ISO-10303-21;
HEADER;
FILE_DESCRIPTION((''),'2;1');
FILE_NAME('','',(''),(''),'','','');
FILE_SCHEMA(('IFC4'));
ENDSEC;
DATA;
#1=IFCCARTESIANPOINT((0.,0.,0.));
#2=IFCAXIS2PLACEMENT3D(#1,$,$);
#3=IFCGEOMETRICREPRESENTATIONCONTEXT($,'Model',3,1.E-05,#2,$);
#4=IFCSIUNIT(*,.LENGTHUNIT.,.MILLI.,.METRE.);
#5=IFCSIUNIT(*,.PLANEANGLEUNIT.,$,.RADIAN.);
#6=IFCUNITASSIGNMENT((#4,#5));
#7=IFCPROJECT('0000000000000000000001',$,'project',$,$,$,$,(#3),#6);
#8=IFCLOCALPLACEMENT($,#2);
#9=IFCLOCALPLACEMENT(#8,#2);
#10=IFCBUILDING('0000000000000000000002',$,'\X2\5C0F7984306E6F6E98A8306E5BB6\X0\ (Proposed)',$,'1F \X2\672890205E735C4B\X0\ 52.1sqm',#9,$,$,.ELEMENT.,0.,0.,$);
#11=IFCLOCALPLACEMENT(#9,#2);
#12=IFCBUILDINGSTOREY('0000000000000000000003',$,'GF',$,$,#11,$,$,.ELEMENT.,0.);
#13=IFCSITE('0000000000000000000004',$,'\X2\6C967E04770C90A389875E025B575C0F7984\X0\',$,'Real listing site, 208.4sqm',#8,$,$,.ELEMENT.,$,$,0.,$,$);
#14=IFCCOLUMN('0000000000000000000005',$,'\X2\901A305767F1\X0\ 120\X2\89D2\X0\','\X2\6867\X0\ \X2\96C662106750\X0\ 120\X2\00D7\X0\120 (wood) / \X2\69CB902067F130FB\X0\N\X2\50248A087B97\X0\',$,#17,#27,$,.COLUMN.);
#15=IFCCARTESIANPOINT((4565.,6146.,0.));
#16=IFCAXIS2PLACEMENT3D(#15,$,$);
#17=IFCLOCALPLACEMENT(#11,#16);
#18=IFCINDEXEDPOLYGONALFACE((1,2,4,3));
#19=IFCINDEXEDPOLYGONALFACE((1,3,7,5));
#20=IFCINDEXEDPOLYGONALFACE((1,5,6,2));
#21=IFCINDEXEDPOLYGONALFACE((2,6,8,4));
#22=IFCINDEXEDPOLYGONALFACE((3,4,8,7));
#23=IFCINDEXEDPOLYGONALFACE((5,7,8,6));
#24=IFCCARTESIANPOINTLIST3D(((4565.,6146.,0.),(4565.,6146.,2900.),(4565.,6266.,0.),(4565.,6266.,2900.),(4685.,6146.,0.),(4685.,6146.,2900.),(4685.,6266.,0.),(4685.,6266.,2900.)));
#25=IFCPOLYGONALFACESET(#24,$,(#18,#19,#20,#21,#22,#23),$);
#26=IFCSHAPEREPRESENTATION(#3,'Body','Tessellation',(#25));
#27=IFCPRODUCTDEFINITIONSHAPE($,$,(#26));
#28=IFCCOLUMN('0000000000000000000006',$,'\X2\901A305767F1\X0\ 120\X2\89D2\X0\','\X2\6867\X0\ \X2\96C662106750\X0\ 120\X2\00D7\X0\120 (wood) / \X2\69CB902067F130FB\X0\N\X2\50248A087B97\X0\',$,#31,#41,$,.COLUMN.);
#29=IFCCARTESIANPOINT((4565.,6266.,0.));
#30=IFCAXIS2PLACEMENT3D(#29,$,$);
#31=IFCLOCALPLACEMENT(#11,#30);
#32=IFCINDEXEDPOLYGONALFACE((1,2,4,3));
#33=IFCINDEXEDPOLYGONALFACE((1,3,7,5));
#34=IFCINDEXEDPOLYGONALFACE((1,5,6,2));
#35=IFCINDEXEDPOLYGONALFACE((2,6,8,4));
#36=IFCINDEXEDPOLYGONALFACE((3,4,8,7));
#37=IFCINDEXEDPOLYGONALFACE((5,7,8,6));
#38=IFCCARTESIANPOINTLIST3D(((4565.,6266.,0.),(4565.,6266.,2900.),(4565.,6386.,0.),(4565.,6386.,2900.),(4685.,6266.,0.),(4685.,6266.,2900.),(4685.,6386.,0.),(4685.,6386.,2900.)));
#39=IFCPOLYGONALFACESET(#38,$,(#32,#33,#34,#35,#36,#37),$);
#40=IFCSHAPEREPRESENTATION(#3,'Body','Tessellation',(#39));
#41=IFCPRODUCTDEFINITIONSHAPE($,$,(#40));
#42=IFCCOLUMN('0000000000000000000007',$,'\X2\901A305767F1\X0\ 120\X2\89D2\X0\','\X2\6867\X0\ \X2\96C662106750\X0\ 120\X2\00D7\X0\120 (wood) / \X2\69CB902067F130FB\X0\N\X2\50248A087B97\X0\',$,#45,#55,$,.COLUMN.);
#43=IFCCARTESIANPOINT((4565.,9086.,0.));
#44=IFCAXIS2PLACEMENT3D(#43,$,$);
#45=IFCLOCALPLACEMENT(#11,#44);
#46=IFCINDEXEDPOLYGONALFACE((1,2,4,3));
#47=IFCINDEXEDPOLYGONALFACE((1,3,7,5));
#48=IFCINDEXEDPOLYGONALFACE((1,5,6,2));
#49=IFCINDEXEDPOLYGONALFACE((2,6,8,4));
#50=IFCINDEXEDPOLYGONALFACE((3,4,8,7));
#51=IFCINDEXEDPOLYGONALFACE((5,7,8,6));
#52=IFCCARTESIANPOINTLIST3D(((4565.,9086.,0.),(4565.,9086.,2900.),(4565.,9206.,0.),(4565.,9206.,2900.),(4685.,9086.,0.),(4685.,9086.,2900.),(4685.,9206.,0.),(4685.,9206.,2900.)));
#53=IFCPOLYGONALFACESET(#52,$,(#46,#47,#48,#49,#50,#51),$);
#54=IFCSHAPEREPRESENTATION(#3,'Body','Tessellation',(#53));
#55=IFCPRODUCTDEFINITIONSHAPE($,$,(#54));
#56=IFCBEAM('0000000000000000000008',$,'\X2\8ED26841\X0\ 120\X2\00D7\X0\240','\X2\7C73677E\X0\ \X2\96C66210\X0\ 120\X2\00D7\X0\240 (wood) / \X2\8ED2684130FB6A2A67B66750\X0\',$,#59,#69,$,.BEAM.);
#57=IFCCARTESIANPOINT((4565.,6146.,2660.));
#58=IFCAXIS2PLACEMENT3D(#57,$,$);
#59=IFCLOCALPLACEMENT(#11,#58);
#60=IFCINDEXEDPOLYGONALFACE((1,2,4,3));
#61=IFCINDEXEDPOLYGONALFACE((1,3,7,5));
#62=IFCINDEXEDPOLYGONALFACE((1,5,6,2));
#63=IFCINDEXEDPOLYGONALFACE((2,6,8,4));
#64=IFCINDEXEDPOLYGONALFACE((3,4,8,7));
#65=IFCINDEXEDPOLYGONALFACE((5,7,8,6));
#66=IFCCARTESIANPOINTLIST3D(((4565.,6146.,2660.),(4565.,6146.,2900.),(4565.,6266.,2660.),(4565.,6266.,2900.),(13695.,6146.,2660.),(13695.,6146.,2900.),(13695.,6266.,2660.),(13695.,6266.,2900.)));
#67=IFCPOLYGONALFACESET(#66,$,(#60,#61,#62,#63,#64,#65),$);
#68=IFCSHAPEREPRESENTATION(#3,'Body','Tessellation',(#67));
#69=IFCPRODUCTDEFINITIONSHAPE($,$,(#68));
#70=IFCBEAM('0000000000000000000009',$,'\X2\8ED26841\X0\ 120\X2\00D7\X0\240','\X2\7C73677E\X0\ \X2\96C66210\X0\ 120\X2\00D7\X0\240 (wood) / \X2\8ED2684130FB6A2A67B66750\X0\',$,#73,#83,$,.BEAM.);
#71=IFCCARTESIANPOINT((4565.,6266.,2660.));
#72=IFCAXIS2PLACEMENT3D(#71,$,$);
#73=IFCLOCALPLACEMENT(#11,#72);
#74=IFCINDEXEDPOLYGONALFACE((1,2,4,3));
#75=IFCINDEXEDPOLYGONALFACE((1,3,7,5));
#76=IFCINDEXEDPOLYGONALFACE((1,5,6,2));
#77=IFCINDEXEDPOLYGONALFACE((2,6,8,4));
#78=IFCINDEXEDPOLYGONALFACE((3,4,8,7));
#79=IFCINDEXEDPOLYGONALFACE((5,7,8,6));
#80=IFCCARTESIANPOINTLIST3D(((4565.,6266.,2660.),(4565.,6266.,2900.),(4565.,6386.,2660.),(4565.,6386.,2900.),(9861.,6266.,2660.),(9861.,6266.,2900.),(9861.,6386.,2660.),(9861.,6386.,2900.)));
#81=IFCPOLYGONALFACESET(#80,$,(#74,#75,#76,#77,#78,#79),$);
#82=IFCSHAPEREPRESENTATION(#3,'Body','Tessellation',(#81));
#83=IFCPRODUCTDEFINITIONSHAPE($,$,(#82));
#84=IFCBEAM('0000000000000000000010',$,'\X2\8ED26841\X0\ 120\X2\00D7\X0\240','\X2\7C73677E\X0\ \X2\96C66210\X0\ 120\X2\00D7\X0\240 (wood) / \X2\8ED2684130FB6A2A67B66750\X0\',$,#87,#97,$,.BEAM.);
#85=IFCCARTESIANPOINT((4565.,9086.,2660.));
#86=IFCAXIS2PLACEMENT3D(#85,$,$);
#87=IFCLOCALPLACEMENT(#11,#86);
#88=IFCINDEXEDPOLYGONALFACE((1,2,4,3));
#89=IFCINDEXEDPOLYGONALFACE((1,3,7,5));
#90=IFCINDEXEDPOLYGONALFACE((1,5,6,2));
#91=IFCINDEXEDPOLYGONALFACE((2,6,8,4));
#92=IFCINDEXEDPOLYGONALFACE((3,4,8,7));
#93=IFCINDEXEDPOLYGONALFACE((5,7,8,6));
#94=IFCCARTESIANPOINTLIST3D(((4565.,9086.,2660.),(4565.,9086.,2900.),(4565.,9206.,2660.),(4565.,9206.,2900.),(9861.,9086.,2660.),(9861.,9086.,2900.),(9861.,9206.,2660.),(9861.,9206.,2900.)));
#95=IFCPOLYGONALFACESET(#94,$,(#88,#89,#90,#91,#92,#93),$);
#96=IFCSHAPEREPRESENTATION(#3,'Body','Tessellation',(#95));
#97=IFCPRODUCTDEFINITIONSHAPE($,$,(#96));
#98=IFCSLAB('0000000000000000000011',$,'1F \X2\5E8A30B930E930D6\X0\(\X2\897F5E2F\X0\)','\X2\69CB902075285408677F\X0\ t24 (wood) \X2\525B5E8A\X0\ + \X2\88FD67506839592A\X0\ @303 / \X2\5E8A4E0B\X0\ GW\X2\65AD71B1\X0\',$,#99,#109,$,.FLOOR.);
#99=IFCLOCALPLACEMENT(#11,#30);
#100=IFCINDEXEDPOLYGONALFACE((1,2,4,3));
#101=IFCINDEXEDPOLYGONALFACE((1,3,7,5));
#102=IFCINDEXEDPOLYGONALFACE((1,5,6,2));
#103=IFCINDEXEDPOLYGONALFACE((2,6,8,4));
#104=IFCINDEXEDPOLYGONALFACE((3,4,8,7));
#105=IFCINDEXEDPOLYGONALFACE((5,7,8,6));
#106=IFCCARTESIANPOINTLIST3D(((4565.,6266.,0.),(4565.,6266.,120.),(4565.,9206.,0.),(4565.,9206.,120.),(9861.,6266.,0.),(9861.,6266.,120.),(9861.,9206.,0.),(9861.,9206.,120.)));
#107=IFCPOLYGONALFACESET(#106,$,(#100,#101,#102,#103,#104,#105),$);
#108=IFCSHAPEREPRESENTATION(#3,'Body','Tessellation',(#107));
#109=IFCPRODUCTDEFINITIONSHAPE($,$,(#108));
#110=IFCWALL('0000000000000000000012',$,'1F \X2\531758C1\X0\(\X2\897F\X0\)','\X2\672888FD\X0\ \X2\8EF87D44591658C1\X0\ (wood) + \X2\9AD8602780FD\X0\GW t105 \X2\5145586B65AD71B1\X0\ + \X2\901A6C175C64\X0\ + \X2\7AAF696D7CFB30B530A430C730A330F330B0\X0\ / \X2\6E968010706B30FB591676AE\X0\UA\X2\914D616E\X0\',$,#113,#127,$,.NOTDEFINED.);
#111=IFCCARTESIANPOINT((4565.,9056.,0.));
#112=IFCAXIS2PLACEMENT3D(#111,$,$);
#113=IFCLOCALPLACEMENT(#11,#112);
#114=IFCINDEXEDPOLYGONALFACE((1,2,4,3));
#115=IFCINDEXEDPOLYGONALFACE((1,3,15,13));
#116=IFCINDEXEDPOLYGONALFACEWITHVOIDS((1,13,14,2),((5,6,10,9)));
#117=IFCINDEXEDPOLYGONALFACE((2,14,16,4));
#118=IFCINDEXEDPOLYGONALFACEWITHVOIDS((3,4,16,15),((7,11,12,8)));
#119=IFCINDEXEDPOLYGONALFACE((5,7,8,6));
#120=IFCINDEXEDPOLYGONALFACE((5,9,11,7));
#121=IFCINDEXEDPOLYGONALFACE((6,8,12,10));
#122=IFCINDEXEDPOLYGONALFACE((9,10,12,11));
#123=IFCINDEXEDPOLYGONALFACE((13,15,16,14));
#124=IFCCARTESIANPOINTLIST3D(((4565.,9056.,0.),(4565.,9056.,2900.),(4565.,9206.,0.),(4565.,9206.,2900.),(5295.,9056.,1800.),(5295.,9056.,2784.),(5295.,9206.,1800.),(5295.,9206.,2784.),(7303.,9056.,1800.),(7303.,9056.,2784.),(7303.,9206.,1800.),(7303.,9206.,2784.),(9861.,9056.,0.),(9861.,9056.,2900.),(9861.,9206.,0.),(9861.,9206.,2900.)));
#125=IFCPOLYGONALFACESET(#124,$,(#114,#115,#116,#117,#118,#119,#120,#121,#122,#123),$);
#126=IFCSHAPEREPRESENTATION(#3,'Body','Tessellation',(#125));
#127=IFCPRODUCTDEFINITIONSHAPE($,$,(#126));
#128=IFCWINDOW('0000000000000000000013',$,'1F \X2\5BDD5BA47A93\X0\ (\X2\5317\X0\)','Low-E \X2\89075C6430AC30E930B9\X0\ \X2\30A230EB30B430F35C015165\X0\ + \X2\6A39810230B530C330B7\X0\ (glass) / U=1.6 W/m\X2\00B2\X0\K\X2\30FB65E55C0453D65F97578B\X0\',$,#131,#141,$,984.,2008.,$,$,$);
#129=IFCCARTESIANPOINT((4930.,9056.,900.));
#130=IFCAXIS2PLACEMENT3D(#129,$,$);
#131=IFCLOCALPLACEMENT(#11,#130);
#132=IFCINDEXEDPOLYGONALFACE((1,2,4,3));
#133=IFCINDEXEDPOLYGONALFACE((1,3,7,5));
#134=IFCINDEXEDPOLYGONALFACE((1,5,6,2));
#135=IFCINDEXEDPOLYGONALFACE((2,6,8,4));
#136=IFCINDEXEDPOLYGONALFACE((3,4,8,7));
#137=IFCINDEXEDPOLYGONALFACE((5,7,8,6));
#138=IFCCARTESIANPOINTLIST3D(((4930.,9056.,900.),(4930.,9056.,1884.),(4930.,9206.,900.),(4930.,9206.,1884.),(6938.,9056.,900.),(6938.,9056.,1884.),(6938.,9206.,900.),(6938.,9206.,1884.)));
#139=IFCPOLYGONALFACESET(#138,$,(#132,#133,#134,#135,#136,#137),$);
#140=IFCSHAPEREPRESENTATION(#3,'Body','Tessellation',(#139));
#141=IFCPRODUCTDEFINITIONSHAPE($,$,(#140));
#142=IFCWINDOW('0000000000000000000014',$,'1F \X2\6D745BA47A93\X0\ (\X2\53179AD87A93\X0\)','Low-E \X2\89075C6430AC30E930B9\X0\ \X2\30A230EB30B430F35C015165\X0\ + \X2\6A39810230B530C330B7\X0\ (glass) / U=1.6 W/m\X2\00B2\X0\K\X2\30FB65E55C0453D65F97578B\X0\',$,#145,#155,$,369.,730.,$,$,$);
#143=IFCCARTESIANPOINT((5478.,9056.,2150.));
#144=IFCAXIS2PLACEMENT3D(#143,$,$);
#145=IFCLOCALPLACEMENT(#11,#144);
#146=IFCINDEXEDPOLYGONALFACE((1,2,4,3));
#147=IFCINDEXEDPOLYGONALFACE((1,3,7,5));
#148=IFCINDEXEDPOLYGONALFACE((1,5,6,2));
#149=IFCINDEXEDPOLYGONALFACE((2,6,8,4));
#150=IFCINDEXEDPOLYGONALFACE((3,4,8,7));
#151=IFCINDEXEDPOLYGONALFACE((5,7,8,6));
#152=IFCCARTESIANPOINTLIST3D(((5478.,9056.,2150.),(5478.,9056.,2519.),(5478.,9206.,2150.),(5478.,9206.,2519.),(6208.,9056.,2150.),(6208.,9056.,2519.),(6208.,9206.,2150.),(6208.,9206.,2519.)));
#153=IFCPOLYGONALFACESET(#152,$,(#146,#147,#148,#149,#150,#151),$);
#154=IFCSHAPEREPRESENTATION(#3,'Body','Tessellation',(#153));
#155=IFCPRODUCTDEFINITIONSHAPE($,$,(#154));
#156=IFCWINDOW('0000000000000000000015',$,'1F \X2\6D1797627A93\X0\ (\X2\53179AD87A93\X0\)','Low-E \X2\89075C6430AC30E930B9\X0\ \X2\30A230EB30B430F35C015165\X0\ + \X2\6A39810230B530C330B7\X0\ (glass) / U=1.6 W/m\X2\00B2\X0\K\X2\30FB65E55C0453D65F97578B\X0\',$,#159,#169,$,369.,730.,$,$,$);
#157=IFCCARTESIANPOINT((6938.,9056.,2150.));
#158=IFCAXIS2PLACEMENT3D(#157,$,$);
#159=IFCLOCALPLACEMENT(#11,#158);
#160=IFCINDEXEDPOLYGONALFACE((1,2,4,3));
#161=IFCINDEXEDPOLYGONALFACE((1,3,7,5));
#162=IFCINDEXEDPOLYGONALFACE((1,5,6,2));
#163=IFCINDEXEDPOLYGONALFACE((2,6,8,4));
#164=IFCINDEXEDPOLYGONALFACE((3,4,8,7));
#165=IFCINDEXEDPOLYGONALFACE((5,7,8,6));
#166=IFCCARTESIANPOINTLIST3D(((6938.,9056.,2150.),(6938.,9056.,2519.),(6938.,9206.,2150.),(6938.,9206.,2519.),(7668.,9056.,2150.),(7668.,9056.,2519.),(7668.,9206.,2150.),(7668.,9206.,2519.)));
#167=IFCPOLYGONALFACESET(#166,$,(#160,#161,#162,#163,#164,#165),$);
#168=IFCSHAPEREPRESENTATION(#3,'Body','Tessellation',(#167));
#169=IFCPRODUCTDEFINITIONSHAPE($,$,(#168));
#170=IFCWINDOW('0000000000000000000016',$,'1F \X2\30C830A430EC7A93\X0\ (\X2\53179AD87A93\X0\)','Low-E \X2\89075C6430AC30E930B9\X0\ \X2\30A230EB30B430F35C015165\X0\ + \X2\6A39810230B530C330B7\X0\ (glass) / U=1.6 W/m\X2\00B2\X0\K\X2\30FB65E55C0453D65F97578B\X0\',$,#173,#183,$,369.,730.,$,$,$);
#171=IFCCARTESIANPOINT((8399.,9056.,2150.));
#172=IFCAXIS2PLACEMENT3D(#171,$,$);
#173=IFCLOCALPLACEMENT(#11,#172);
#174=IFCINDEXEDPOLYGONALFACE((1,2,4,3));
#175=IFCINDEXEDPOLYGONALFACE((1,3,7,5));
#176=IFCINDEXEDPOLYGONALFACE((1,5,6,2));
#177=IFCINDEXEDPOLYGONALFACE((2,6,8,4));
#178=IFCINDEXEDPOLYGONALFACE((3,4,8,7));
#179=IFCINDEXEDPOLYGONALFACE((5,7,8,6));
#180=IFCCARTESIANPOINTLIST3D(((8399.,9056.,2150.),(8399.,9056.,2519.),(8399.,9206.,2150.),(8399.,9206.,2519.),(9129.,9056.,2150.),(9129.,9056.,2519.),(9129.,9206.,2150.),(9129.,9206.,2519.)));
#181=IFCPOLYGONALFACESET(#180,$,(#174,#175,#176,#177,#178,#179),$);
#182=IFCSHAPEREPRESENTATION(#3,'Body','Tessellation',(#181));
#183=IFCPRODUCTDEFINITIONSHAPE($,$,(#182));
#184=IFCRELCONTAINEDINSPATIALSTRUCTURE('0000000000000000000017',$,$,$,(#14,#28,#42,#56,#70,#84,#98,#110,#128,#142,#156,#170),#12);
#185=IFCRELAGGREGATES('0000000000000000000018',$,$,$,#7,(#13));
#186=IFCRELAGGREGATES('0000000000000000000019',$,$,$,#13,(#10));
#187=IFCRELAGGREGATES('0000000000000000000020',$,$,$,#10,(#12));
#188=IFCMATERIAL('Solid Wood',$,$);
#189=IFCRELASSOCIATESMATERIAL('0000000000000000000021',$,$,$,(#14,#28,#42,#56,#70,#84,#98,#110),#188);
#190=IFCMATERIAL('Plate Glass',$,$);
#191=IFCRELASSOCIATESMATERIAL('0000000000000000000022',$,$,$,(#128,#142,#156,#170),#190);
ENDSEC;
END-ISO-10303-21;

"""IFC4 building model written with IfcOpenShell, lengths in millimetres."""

from ifc_helpers import new_model, si_unit, frame, frame_2d, origin, place, context, project, spatial, rectangle, extrude, material, element, fill, save


model = new_model("IFC4")

# Units and contexts
model_context = context("Model", 3, precision=1e-05, world=origin())
ifc_project = project(units=[si_unit("LENGTHUNIT", "METRE", prefix="MILLI"), si_unit("PLANEANGLEUNIT", "RADIAN")], contexts=[model_context])

# Site, building, storey
site_placement = place(None, origin())
site = spatial("IfcSite", under=ifc_project, at=site_placement, Name="沖縄県那覇市字小禄", ObjectType="Real listing site, 208.4sqm", CompositionType="ELEMENT", RefElevation=0.0)
building_placement = place(site_placement, origin())
building = spatial("IfcBuilding", under=site, at=building_placement, Name="小禄の潮風の家 (Proposed)", ObjectType="1F 木造平屋 52.1sqm", CompositionType="ELEMENT", ElevationOfRefHeight=0.0, ElevationOfTerrain=0.0)
storey_placement = place(building_placement, origin())
storey = spatial("IfcBuildingStorey", under=building, at=storey_placement, Name="GF", CompositionType="ELEMENT", Elevation=0.0)

# Columns
ifc_material_1 = material(Name="Solid Wood")
column_1_placement = place(storey_placement, frame((4565.0, 6146.0, 0.0)))
element("IfcColumn", 1, at=column_1_placement, inside=storey, material=ifc_material_1, Name="通し柱 120角", Description="桧 集成材 120×120 (wood) / 構造柱・N値計算", PredefinedType="COLUMN", context=model_context, shape_type="SweptSolid", body=[
    extrude(rectangle(XDim=120.0, YDim=120.0, at=frame_2d((60.0, 60.0))), frame((4565.0, 6146.0, 0.0)), (0.0, 0.0, 1.0), 2900.0),
])
column_2_placement = place(storey_placement, frame((4565.0, 6266.0, 0.0)))
element("IfcColumn", 2, at=column_2_placement, inside=storey, material=ifc_material_1, Name="通し柱 120角", Description="桧 集成材 120×120 (wood) / 構造柱・N値計算", PredefinedType="COLUMN", context=model_context, shape_type="SweptSolid", body=[
    extrude(rectangle(XDim=120.0, YDim=120.0, at=frame_2d((60.0, 60.0))), frame((4565.0, 6266.0, 0.0)), (0.0, 0.0, 1.0), 2900.0),
])
column_3_placement = place(storey_placement, frame((4565.0, 9086.0, 0.0)))
element("IfcColumn", 3, at=column_3_placement, inside=storey, material=ifc_material_1, Name="通し柱 120角", Description="桧 集成材 120×120 (wood) / 構造柱・N値計算", PredefinedType="COLUMN", context=model_context, shape_type="SweptSolid", body=[
    extrude(rectangle(XDim=120.0, YDim=120.0, at=frame_2d((60.0, 60.0))), frame((4565.0, 9086.0, 0.0)), (0.0, 0.0, 1.0), 2900.0),
])

# Beams
beam_1_placement = place(storey_placement, frame((4565.0, 6146.0, 2660.0)))
element("IfcBeam", 4, at=beam_1_placement, inside=storey, material=ifc_material_1, Name="軒桁 120×240", Description="米松 集成 120×240 (wood) / 軒桁・横架材", PredefinedType="BEAM", context=model_context, shape_type="SweptSolid", body=[
    extrude(rectangle(XDim=9130.0, YDim=120.0, at=frame_2d((4565.0, 60.0))), frame((4565.0, 6146.0, 2660.0)), (0.0, 0.0, 1.0), 240.0),
])
beam_2_placement = place(storey_placement, frame((4565.0, 6266.0, 2660.0)))
element("IfcBeam", 5, at=beam_2_placement, inside=storey, material=ifc_material_1, Name="軒桁 120×240", Description="米松 集成 120×240 (wood) / 軒桁・横架材", PredefinedType="BEAM", context=model_context, shape_type="SweptSolid", body=[
    extrude(rectangle(XDim=5296.0, YDim=120.0, at=frame_2d((2648.0, 60.0))), frame((4565.0, 6266.0, 2660.0)), (0.0, 0.0, 1.0), 240.0),
])
beam_3_placement = place(storey_placement, frame((4565.0, 9086.0, 2660.0)))
element("IfcBeam", 6, at=beam_3_placement, inside=storey, material=ifc_material_1, Name="軒桁 120×240", Description="米松 集成 120×240 (wood) / 軒桁・横架材", PredefinedType="BEAM", context=model_context, shape_type="SweptSolid", body=[
    extrude(rectangle(XDim=5296.0, YDim=120.0, at=frame_2d((2648.0, 60.0))), frame((4565.0, 9086.0, 2660.0)), (0.0, 0.0, 1.0), 240.0),
])

# Slab
slab_placement = place(storey_placement, frame((4565.0, 6266.0, 0.0)))
element("IfcSlab", 7, at=slab_placement, inside=storey, material=ifc_material_1, Name="1F 床スラブ(西帯)", Description="構造用合板 t24 (wood) 剛床 + 製材根太 @303 / 床下 GW断熱", PredefinedType="FLOOR", context=model_context, shape_type="SweptSolid", body=[
    extrude(rectangle(XDim=5296.0, YDim=2940.0, at=frame_2d((2648.0, 1470.0))), frame((4565.0, 6266.0, 0.0)), (0.0, 0.0, 1.0), 120.0),
])

# Wall, openings, windows
wall_1_placement = place(storey_placement, frame((4565.0, 9056.0, 0.0)))
wall_1 = element("IfcWall", 8, at=wall_1_placement, inside=storey, material=ifc_material_1, Name="1F 北壁(西)", Description="木製 軸組外壁 (wood) + 高性能GW t105 充填断熱 + 通気層 + 窯業系サイディング / 準耐火・外皮UA配慮", PredefinedType="NOTDEFINED", context=model_context, shape_type="SweptSolid", body=[
    extrude(rectangle(XDim=5296.0, YDim=150.0, at=frame_2d((2648.0, 75.0))), frame((4565.0, 9056.0, 0.0)), (0.0, 0.0, 1.0), 2900.0),
])
opening_1_placement = place(storey_placement, frame((4930.0, 9056.0, 900.0)))
opening_1 = element("IfcOpeningElement", 9, at=opening_1_placement, cuts=wall_1, PredefinedType="NOTDEFINED", context=model_context, shape_type="SweptSolid", body=[
    extrude(rectangle(XDim=2008.0, YDim=150.0, at=frame_2d((1004.0, 75.0))), frame((4930.0, 9056.0, 900.0)), (0.0, 0.0, 1.0), 984.0),
])
opening_2_placement = place(storey_placement, frame((5478.0, 9056.0, 2150.0)))
opening_2 = element("IfcOpeningElement", 10, at=opening_2_placement, cuts=wall_1, PredefinedType="NOTDEFINED", context=model_context, shape_type="SweptSolid", body=[
    extrude(rectangle(XDim=730.0, YDim=150.0, at=frame_2d((365.0, 75.0))), frame((5478.0, 9056.0, 2150.0)), (0.0, 0.0, 1.0), 369.0),
])
opening_3_placement = place(storey_placement, frame((6938.0, 9056.0, 2150.0)))
opening_3 = element("IfcOpeningElement", 11, at=opening_3_placement, cuts=wall_1, PredefinedType="NOTDEFINED", context=model_context, shape_type="SweptSolid", body=[
    extrude(rectangle(XDim=730.0, YDim=150.0, at=frame_2d((365.0, 75.0))), frame((6938.0, 9056.0, 2150.0)), (0.0, 0.0, 1.0), 369.0),
])
opening_4_placement = place(storey_placement, frame((8399.0, 9056.0, 2150.0)))
opening_4 = element("IfcOpeningElement", 12, at=opening_4_placement, cuts=wall_1, PredefinedType="NOTDEFINED", context=model_context, shape_type="SweptSolid", body=[
    extrude(rectangle(XDim=730.0, YDim=150.0, at=frame_2d((365.0, 75.0))), frame((8399.0, 9056.0, 2150.0)), (0.0, 0.0, 1.0), 369.0),
])
ifc_material_2 = material(Name="Plate Glass")
window_1_placement = place(storey_placement, frame((4930.0, 9056.0, 900.0)))
window_1 = element("IfcWindow", 13, at=window_1_placement, inside=storey, material=ifc_material_2, Name="1F 寝室窓 (北)", Description="Low-E 複層ガラス アルゴン封入 + 樹脂サッシ (glass) / U=1.6 W/m²K・日射取得型", OverallHeight=984.0, OverallWidth=2008.0, context=model_context, shape_type="SweptSolid", body=[
    extrude(rectangle(XDim=2008.0, YDim=150.0, at=frame_2d((1004.0, 75.0))), frame((4930.0, 9056.0, 900.0)), (0.0, 0.0, 1.0), 984.0),
])
fill(opening_1, window_1)
window_2_placement = place(storey_placement, frame((5478.0, 9056.0, 2150.0)))
window_2 = element("IfcWindow", 14, at=window_2_placement, inside=storey, material=ifc_material_2, Name="1F 浴室窓 (北高窓)", Description="Low-E 複層ガラス アルゴン封入 + 樹脂サッシ (glass) / U=1.6 W/m²K・日射取得型", OverallHeight=369.0, OverallWidth=730.0, context=model_context, shape_type="SweptSolid", body=[
    extrude(rectangle(XDim=730.0, YDim=150.0, at=frame_2d((365.0, 75.0))), frame((5478.0, 9056.0, 2150.0)), (0.0, 0.0, 1.0), 369.0),
])
fill(opening_2, window_2)
window_3_placement = place(storey_placement, frame((6938.0, 9056.0, 2150.0)))
window_3 = element("IfcWindow", 15, at=window_3_placement, inside=storey, material=ifc_material_2, Name="1F 洗面窓 (北高窓)", Description="Low-E 複層ガラス アルゴン封入 + 樹脂サッシ (glass) / U=1.6 W/m²K・日射取得型", OverallHeight=369.0, OverallWidth=730.0, context=model_context, shape_type="SweptSolid", body=[
    extrude(rectangle(XDim=730.0, YDim=150.0, at=frame_2d((365.0, 75.0))), frame((6938.0, 9056.0, 2150.0)), (0.0, 0.0, 1.0), 369.0),
])
fill(opening_3, window_3)
window_4_placement = place(storey_placement, frame((8399.0, 9056.0, 2150.0)))
window_4 = element("IfcWindow", 16, at=window_4_placement, inside=storey, material=ifc_material_2, Name="1F トイレ窓 (北高窓)", Description="Low-E 複層ガラス アルゴン封入 + 樹脂サッシ (glass) / U=1.6 W/m²K・日射取得型", OverallHeight=369.0, OverallWidth=730.0, context=model_context, shape_type="SweptSolid", body=[
    extrude(rectangle(XDim=730.0, YDim=150.0, at=frame_2d((365.0, 75.0))), frame((8399.0, 9056.0, 2150.0)), (0.0, 0.0, 1.0), 369.0),
])
fill(opening_4, window_4)

save(model, "model.ifc")
